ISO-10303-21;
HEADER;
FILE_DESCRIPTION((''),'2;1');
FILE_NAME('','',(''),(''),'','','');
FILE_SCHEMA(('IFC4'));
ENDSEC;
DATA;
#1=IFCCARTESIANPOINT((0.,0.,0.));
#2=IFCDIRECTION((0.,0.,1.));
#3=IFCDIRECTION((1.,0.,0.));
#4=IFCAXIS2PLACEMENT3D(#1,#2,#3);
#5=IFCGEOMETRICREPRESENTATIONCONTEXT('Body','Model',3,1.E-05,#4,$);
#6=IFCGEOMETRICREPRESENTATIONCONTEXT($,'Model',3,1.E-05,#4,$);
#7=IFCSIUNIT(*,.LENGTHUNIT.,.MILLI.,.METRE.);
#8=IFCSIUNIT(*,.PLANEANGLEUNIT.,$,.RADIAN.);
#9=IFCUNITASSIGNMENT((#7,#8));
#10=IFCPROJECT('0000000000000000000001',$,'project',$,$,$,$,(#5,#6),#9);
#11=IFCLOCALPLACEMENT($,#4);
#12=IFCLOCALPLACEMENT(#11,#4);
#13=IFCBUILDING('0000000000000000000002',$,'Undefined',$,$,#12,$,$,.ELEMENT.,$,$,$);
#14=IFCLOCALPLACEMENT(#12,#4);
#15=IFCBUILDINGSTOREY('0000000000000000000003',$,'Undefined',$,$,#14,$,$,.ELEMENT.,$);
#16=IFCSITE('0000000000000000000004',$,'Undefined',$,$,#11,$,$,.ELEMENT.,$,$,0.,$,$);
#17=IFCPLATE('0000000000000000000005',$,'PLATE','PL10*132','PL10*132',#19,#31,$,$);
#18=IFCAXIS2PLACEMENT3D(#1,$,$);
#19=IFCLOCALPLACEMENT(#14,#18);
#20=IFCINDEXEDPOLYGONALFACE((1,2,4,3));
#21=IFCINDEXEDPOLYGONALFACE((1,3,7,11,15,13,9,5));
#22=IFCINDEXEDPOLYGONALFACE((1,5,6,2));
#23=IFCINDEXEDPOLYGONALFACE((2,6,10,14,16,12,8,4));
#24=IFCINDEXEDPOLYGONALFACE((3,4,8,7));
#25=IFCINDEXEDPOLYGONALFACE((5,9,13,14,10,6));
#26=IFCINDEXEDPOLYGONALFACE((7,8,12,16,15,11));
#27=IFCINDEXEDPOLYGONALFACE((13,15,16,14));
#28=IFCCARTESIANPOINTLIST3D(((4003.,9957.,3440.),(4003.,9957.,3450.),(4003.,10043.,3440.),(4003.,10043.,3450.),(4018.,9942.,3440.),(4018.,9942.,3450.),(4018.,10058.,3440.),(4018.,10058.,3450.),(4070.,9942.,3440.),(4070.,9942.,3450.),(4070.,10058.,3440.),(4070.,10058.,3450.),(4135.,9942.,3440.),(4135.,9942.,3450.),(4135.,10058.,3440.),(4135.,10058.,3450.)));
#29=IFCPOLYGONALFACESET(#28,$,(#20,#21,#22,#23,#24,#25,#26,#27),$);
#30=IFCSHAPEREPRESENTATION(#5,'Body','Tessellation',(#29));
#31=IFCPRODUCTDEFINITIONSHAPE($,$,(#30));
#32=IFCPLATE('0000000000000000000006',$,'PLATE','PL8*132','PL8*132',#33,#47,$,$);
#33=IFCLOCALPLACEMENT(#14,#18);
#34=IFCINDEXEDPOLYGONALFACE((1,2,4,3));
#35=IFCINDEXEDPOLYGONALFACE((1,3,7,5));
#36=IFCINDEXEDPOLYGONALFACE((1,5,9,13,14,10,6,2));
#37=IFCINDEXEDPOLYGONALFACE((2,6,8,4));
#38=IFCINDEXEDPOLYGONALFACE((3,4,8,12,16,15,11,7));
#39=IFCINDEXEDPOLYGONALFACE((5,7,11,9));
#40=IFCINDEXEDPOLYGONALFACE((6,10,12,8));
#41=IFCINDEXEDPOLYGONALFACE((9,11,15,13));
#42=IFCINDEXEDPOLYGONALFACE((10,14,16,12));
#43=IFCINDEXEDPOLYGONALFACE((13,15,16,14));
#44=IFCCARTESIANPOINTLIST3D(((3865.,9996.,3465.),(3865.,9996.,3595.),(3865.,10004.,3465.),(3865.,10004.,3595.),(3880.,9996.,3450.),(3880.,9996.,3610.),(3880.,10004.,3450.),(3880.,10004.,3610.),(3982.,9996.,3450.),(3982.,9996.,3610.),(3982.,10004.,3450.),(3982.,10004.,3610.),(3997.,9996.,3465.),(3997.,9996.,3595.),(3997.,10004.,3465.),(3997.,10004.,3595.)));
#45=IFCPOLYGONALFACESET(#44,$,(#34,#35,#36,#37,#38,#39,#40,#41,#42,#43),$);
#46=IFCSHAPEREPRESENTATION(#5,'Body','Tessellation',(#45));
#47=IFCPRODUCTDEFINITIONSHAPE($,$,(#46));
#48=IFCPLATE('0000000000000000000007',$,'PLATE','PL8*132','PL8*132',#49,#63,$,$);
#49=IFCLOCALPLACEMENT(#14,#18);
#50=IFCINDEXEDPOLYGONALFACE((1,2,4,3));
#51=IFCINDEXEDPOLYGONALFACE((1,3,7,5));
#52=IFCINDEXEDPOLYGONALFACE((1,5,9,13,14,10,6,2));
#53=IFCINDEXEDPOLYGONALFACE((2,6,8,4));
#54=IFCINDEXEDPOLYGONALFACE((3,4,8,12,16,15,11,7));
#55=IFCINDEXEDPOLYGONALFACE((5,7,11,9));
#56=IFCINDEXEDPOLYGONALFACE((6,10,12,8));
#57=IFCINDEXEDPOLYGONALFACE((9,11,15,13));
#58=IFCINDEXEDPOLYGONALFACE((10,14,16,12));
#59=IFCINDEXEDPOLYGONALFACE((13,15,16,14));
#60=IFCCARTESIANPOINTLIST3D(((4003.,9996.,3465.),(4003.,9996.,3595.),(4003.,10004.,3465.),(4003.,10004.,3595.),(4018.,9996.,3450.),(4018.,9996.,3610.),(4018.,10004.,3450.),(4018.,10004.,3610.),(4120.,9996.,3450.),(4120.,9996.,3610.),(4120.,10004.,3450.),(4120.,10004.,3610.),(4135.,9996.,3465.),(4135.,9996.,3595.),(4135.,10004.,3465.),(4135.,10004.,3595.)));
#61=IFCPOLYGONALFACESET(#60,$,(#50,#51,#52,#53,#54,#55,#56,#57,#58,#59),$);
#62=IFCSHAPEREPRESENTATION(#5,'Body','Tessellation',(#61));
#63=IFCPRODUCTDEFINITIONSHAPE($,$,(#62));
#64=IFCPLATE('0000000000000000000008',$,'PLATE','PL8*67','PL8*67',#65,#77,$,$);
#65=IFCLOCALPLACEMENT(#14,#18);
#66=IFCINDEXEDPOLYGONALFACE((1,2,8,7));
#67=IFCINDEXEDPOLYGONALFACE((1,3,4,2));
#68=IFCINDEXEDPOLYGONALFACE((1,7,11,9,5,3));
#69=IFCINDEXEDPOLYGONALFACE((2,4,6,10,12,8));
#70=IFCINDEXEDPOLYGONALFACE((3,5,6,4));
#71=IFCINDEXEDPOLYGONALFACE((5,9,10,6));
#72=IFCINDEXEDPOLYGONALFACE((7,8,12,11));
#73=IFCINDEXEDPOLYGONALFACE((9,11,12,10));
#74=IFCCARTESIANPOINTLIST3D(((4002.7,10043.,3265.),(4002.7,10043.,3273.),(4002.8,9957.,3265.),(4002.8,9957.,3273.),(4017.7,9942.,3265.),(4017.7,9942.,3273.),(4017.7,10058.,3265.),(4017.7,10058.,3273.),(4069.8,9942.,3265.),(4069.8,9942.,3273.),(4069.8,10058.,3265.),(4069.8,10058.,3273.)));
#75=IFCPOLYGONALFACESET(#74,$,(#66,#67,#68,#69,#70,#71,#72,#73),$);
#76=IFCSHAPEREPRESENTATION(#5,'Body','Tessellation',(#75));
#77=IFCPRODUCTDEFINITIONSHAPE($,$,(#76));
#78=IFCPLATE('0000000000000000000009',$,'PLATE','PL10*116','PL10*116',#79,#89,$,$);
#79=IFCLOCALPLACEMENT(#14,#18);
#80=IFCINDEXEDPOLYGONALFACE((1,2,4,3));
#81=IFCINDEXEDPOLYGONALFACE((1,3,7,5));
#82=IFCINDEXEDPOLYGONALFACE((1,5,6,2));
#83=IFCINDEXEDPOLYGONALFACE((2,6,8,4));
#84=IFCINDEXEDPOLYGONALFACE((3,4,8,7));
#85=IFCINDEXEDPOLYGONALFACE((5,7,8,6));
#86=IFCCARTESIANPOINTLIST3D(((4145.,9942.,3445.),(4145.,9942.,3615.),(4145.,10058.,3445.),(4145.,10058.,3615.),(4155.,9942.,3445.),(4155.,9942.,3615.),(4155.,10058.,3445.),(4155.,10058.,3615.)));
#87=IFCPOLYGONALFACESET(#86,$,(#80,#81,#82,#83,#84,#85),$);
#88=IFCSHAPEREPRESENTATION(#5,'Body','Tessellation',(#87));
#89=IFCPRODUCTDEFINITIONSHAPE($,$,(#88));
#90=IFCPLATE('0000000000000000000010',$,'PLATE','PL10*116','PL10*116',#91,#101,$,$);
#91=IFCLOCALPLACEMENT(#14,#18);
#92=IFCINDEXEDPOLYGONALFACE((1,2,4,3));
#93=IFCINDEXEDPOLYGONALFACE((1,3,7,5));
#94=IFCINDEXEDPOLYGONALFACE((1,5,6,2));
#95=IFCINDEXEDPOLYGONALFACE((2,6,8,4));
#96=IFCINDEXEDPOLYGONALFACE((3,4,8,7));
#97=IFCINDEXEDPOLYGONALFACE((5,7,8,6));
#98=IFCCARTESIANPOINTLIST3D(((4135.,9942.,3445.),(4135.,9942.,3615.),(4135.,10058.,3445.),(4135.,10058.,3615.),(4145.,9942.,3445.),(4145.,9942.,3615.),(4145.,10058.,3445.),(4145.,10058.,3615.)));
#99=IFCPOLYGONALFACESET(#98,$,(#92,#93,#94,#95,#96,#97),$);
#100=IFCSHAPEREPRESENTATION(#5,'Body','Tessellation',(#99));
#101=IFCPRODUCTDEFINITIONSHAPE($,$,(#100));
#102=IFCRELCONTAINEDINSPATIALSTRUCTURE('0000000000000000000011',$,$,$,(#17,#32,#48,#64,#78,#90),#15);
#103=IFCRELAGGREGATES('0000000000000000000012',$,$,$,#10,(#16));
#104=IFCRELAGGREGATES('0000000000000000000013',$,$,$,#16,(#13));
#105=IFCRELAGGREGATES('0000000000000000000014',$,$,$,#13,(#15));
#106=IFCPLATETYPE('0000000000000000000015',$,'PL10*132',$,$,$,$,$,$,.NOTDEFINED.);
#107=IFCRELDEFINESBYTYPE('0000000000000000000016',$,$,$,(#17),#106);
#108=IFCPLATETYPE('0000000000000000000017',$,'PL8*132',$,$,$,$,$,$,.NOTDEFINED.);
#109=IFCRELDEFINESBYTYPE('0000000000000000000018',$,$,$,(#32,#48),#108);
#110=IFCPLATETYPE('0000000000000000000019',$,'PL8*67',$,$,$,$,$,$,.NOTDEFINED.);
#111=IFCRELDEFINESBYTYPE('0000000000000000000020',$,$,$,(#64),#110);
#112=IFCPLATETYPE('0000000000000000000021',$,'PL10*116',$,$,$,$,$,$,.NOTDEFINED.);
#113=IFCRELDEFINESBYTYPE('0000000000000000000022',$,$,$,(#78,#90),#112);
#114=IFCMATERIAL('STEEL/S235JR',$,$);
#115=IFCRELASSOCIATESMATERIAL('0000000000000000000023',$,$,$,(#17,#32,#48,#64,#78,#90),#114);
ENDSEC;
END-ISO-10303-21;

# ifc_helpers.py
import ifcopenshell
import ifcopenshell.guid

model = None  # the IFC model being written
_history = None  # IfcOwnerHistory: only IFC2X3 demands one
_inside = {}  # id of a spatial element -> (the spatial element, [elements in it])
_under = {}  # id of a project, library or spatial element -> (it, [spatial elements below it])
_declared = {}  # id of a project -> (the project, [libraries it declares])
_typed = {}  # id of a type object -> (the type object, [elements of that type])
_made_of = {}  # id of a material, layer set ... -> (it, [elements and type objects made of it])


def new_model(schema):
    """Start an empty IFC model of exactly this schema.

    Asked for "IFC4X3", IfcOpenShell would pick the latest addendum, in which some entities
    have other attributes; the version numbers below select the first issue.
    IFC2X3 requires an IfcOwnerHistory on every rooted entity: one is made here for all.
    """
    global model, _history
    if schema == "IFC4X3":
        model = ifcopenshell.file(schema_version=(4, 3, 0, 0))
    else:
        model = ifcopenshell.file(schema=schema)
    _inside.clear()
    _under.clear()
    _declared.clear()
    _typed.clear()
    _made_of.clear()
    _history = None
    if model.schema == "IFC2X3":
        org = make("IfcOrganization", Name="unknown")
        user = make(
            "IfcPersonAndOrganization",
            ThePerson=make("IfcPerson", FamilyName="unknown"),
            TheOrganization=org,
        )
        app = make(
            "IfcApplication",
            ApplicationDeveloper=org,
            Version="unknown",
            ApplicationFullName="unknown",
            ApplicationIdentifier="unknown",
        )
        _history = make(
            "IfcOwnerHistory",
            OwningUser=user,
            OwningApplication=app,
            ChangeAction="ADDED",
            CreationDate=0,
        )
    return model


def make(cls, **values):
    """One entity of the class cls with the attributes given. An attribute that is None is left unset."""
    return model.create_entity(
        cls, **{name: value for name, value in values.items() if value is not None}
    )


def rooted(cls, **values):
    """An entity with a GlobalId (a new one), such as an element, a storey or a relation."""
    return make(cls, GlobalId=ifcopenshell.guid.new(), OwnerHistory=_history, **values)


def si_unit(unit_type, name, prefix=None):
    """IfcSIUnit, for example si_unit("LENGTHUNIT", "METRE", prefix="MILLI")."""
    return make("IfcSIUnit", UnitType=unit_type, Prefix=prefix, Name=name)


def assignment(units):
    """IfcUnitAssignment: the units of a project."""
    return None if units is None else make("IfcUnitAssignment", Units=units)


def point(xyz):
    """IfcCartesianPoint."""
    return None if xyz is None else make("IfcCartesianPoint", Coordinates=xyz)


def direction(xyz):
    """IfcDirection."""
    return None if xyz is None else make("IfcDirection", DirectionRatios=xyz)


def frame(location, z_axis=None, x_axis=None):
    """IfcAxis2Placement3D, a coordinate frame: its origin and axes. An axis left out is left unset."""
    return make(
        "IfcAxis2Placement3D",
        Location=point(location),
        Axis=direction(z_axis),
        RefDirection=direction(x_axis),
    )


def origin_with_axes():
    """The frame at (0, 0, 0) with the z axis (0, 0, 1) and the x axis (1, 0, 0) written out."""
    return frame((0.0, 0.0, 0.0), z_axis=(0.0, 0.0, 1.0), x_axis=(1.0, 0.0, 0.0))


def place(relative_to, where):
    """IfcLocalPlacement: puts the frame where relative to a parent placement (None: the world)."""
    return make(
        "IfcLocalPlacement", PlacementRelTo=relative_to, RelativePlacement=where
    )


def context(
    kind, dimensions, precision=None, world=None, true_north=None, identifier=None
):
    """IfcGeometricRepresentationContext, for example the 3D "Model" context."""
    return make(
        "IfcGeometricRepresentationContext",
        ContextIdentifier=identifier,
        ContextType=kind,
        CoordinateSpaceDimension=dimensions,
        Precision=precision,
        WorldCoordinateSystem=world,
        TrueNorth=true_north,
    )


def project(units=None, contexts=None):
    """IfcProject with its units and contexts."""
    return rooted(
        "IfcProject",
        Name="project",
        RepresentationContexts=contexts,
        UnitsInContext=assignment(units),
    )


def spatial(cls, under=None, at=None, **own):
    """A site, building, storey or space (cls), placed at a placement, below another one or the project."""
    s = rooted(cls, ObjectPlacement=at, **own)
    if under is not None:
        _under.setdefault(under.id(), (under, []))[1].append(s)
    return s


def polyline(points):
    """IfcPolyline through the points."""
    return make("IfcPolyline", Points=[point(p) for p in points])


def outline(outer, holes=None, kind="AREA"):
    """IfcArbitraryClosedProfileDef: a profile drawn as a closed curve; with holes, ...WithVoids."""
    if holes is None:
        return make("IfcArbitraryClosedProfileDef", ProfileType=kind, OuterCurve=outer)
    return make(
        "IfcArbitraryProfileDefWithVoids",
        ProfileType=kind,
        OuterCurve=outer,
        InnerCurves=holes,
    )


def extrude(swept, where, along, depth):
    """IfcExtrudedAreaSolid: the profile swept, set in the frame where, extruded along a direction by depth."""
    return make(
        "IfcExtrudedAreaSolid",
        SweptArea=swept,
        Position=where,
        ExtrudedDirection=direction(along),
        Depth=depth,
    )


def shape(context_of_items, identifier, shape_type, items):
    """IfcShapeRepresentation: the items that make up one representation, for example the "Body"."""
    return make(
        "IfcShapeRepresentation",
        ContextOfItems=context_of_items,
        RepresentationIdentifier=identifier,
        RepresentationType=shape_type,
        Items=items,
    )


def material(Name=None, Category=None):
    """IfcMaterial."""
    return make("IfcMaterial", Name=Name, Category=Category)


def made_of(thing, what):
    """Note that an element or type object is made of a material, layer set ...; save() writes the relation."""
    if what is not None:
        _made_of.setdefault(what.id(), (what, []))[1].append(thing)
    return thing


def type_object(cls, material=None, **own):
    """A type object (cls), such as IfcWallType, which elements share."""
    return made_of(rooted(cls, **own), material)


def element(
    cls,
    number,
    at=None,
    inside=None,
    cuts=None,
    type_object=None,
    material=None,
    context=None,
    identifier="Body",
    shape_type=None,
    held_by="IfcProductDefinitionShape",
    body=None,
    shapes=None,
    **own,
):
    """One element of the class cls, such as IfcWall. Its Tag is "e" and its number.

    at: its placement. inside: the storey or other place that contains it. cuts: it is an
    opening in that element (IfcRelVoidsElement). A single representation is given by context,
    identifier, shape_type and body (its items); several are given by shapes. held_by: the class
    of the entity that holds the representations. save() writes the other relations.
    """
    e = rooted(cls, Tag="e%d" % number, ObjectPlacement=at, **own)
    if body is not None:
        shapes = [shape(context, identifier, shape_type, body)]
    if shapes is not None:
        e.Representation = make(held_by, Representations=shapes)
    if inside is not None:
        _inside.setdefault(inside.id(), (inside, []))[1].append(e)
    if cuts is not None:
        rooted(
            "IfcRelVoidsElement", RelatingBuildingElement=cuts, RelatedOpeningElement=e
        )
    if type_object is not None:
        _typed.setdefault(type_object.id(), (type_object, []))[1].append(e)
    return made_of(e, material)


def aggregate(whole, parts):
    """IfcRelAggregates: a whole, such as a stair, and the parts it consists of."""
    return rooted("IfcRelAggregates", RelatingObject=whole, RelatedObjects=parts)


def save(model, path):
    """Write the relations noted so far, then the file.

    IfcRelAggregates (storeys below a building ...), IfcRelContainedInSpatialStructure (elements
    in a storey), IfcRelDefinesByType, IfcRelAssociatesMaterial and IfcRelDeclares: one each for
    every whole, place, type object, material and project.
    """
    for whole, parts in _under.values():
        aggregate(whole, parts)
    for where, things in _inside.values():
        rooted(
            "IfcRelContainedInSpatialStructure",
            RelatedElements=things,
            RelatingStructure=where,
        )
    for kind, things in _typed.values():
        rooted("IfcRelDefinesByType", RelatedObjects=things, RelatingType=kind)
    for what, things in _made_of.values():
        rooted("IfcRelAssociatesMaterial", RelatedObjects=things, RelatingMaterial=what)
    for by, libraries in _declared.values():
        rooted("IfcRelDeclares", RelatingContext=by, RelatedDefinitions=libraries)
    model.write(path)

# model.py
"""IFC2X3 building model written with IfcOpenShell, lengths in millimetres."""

from ifc_helpers import new_model, si_unit, frame, origin_with_axes, place, context, project, spatial, polyline, outline, extrude, material, type_object, element, save


model = new_model("IFC2X3")

# Units and contexts
model_context_1 = context("Model", 3, precision=1e-05, world=origin_with_axes(), identifier="Body")
model_context_2 = context("Model", 3, precision=1e-05, world=origin_with_axes())
ifc_project = project(units=[si_unit("LENGTHUNIT", "METRE", prefix="MILLI"), si_unit("PLANEANGLEUNIT", "RADIAN")], contexts=[model_context_1, model_context_2])

# Site, building, storey
site_placement = place(None, origin_with_axes())
site = spatial("IfcSite", under=ifc_project, at=site_placement, Name="Undefined", CompositionType="ELEMENT", RefElevation=0.0)
building_placement = place(site_placement, origin_with_axes())
building = spatial("IfcBuilding", under=site, at=building_placement, Name="Undefined", CompositionType="ELEMENT")
storey_placement = place(building_placement, origin_with_axes())
storey = spatial("IfcBuildingStorey", under=building, at=storey_placement, Name="Undefined", CompositionType="ELEMENT")

# Shared definitions
ifc_material = material(Name="STEEL/S235JR")

# Plates
plate_type_1 = type_object("IfcPlateType", Name="PL10*132", PredefinedType="NOTDEFINED")
for number, where, z_axis, x_axis, name in (
    (1, (4003.0, 10058.0, 3445.0), (0.0, 0.0, -1.0), (1.0, 0.0, 0.0), "PLATE"),
):
    element("IfcPlate", number, at=place(storey_placement, frame(where, z_axis=z_axis, x_axis=x_axis)), inside=storey, type_object=plate_type_1, material=ifc_material, Name=name, Description="PL10*132", ObjectType="PL10*132", context=model_context_1, shape_type="SweptSolid", body=[
        extrude(outline(polyline([(0.0, 15.0), (15.0, 0.0), (67.0, 0.0), (132.0, 0.0), (132.0, 116.0), (67.0, 116.0), (15.0, 116.0), (0.0, 101.0), (0.0, 15.0)])), frame((0.0, 0.0, -5.0), z_axis=(0.0, 0.0, 1.0), x_axis=(1.0, 0.0, 0.0)), (0.0, 0.0, 1.0), 10.0),
    ])
plate_type_2 = type_object("IfcPlateType", Name="PL8*132", PredefinedType="NOTDEFINED")
for number, where, z_axis, x_axis, name in (
    (2, (3997.0, 10000.0, 3610.0), (0.0, -1.0, 0.0), (-1.0, 0.0, 0.0), "PLATE"),
    (3, (4003.0, 10000.0, 3610.0), (0.0, 1.0, 0.0), (1.0, 0.0, 0.0), "PLATE"),
):
    element("IfcPlate", number, at=place(storey_placement, frame(where, z_axis=z_axis, x_axis=x_axis)), inside=storey, type_object=plate_type_2, material=ifc_material, Name=name, Description="PL8*132", ObjectType="PL8*132", context=model_context_1, shape_type="SweptSolid", body=[
        extrude(outline(polyline([(0.0, 15.0), (15.0, 0.0), (117.0, 0.0), (132.0, 15.0), (132.0, 145.0), (117.0, 160.0), (15.0, 160.0), (0.0, 145.0), (0.0, 15.0)])), frame((0.0, 0.0, -4.0), z_axis=(0.0, 0.0, 1.0), x_axis=(1.0, 0.0, 0.0)), (0.0, 0.0, 1.0), 8.0),
    ])
plate_type_3 = type_object("IfcPlateType", Name="PL8*67", PredefinedType="NOTDEFINED")
plate_1_placement = place(storey_placement, frame((4002.8, 9942.0, 3269.0), z_axis=(0.0, 0.0, 1.0), x_axis=(1.0, 0.0, 0.0)))
element("IfcPlate", 4, at=plate_1_placement, inside=storey, type_object=plate_type_3, material=ifc_material, Name="PLATE", Description="PL8*67", ObjectType="PL8*67", context=model_context_1, shape_type="SweptSolid", body=[
    extrude(outline(polyline([(0.0, 15.0), (15.0, 0.0), (67.0, 0.0), (67.0, 116.0), (15.0, 116.0), (0.0, 101.0), (0.0, 15.0)])), frame((0.0, 0.0, -4.0), z_axis=(0.0, 0.0, 1.0), x_axis=(1.0, 0.0, 0.0)), (0.0, 0.0, 1.0), 8.0),
])
plate_type_4 = type_object("IfcPlateType", Name="PL10*116", PredefinedType="NOTDEFINED")
for number, where, z_axis, x_axis, name in (
    (5, (4150.0, 10058.0, 3615.0), (1.0, 0.0, 0.0), (0.0, -1.0, 0.0), "PLATE"),
    (6, (4140.0, 10058.0, 3615.0), (1.0, 0.0, 0.0), (0.0, -1.0, 0.0), "PLATE"),
):
    element("IfcPlate", number, at=place(storey_placement, frame(where, z_axis=z_axis, x_axis=x_axis)), inside=storey, type_object=plate_type_4, material=ifc_material, Name=name, Description="PL10*116", ObjectType="PL10*116", context=model_context_1, shape_type="SweptSolid", body=[
        extrude(outline(polyline([(0.0, 0.0), (116.0, 0.0), (116.0, 170.0), (0.0, 170.0), (0.0, 0.0)])), frame((0.0, 0.0, -5.0), z_axis=(0.0, 0.0, 1.0), x_axis=(1.0, 0.0, 0.0)), (0.0, 0.0, 1.0), 10.0),
    ])

save(model, "model.ifc")
